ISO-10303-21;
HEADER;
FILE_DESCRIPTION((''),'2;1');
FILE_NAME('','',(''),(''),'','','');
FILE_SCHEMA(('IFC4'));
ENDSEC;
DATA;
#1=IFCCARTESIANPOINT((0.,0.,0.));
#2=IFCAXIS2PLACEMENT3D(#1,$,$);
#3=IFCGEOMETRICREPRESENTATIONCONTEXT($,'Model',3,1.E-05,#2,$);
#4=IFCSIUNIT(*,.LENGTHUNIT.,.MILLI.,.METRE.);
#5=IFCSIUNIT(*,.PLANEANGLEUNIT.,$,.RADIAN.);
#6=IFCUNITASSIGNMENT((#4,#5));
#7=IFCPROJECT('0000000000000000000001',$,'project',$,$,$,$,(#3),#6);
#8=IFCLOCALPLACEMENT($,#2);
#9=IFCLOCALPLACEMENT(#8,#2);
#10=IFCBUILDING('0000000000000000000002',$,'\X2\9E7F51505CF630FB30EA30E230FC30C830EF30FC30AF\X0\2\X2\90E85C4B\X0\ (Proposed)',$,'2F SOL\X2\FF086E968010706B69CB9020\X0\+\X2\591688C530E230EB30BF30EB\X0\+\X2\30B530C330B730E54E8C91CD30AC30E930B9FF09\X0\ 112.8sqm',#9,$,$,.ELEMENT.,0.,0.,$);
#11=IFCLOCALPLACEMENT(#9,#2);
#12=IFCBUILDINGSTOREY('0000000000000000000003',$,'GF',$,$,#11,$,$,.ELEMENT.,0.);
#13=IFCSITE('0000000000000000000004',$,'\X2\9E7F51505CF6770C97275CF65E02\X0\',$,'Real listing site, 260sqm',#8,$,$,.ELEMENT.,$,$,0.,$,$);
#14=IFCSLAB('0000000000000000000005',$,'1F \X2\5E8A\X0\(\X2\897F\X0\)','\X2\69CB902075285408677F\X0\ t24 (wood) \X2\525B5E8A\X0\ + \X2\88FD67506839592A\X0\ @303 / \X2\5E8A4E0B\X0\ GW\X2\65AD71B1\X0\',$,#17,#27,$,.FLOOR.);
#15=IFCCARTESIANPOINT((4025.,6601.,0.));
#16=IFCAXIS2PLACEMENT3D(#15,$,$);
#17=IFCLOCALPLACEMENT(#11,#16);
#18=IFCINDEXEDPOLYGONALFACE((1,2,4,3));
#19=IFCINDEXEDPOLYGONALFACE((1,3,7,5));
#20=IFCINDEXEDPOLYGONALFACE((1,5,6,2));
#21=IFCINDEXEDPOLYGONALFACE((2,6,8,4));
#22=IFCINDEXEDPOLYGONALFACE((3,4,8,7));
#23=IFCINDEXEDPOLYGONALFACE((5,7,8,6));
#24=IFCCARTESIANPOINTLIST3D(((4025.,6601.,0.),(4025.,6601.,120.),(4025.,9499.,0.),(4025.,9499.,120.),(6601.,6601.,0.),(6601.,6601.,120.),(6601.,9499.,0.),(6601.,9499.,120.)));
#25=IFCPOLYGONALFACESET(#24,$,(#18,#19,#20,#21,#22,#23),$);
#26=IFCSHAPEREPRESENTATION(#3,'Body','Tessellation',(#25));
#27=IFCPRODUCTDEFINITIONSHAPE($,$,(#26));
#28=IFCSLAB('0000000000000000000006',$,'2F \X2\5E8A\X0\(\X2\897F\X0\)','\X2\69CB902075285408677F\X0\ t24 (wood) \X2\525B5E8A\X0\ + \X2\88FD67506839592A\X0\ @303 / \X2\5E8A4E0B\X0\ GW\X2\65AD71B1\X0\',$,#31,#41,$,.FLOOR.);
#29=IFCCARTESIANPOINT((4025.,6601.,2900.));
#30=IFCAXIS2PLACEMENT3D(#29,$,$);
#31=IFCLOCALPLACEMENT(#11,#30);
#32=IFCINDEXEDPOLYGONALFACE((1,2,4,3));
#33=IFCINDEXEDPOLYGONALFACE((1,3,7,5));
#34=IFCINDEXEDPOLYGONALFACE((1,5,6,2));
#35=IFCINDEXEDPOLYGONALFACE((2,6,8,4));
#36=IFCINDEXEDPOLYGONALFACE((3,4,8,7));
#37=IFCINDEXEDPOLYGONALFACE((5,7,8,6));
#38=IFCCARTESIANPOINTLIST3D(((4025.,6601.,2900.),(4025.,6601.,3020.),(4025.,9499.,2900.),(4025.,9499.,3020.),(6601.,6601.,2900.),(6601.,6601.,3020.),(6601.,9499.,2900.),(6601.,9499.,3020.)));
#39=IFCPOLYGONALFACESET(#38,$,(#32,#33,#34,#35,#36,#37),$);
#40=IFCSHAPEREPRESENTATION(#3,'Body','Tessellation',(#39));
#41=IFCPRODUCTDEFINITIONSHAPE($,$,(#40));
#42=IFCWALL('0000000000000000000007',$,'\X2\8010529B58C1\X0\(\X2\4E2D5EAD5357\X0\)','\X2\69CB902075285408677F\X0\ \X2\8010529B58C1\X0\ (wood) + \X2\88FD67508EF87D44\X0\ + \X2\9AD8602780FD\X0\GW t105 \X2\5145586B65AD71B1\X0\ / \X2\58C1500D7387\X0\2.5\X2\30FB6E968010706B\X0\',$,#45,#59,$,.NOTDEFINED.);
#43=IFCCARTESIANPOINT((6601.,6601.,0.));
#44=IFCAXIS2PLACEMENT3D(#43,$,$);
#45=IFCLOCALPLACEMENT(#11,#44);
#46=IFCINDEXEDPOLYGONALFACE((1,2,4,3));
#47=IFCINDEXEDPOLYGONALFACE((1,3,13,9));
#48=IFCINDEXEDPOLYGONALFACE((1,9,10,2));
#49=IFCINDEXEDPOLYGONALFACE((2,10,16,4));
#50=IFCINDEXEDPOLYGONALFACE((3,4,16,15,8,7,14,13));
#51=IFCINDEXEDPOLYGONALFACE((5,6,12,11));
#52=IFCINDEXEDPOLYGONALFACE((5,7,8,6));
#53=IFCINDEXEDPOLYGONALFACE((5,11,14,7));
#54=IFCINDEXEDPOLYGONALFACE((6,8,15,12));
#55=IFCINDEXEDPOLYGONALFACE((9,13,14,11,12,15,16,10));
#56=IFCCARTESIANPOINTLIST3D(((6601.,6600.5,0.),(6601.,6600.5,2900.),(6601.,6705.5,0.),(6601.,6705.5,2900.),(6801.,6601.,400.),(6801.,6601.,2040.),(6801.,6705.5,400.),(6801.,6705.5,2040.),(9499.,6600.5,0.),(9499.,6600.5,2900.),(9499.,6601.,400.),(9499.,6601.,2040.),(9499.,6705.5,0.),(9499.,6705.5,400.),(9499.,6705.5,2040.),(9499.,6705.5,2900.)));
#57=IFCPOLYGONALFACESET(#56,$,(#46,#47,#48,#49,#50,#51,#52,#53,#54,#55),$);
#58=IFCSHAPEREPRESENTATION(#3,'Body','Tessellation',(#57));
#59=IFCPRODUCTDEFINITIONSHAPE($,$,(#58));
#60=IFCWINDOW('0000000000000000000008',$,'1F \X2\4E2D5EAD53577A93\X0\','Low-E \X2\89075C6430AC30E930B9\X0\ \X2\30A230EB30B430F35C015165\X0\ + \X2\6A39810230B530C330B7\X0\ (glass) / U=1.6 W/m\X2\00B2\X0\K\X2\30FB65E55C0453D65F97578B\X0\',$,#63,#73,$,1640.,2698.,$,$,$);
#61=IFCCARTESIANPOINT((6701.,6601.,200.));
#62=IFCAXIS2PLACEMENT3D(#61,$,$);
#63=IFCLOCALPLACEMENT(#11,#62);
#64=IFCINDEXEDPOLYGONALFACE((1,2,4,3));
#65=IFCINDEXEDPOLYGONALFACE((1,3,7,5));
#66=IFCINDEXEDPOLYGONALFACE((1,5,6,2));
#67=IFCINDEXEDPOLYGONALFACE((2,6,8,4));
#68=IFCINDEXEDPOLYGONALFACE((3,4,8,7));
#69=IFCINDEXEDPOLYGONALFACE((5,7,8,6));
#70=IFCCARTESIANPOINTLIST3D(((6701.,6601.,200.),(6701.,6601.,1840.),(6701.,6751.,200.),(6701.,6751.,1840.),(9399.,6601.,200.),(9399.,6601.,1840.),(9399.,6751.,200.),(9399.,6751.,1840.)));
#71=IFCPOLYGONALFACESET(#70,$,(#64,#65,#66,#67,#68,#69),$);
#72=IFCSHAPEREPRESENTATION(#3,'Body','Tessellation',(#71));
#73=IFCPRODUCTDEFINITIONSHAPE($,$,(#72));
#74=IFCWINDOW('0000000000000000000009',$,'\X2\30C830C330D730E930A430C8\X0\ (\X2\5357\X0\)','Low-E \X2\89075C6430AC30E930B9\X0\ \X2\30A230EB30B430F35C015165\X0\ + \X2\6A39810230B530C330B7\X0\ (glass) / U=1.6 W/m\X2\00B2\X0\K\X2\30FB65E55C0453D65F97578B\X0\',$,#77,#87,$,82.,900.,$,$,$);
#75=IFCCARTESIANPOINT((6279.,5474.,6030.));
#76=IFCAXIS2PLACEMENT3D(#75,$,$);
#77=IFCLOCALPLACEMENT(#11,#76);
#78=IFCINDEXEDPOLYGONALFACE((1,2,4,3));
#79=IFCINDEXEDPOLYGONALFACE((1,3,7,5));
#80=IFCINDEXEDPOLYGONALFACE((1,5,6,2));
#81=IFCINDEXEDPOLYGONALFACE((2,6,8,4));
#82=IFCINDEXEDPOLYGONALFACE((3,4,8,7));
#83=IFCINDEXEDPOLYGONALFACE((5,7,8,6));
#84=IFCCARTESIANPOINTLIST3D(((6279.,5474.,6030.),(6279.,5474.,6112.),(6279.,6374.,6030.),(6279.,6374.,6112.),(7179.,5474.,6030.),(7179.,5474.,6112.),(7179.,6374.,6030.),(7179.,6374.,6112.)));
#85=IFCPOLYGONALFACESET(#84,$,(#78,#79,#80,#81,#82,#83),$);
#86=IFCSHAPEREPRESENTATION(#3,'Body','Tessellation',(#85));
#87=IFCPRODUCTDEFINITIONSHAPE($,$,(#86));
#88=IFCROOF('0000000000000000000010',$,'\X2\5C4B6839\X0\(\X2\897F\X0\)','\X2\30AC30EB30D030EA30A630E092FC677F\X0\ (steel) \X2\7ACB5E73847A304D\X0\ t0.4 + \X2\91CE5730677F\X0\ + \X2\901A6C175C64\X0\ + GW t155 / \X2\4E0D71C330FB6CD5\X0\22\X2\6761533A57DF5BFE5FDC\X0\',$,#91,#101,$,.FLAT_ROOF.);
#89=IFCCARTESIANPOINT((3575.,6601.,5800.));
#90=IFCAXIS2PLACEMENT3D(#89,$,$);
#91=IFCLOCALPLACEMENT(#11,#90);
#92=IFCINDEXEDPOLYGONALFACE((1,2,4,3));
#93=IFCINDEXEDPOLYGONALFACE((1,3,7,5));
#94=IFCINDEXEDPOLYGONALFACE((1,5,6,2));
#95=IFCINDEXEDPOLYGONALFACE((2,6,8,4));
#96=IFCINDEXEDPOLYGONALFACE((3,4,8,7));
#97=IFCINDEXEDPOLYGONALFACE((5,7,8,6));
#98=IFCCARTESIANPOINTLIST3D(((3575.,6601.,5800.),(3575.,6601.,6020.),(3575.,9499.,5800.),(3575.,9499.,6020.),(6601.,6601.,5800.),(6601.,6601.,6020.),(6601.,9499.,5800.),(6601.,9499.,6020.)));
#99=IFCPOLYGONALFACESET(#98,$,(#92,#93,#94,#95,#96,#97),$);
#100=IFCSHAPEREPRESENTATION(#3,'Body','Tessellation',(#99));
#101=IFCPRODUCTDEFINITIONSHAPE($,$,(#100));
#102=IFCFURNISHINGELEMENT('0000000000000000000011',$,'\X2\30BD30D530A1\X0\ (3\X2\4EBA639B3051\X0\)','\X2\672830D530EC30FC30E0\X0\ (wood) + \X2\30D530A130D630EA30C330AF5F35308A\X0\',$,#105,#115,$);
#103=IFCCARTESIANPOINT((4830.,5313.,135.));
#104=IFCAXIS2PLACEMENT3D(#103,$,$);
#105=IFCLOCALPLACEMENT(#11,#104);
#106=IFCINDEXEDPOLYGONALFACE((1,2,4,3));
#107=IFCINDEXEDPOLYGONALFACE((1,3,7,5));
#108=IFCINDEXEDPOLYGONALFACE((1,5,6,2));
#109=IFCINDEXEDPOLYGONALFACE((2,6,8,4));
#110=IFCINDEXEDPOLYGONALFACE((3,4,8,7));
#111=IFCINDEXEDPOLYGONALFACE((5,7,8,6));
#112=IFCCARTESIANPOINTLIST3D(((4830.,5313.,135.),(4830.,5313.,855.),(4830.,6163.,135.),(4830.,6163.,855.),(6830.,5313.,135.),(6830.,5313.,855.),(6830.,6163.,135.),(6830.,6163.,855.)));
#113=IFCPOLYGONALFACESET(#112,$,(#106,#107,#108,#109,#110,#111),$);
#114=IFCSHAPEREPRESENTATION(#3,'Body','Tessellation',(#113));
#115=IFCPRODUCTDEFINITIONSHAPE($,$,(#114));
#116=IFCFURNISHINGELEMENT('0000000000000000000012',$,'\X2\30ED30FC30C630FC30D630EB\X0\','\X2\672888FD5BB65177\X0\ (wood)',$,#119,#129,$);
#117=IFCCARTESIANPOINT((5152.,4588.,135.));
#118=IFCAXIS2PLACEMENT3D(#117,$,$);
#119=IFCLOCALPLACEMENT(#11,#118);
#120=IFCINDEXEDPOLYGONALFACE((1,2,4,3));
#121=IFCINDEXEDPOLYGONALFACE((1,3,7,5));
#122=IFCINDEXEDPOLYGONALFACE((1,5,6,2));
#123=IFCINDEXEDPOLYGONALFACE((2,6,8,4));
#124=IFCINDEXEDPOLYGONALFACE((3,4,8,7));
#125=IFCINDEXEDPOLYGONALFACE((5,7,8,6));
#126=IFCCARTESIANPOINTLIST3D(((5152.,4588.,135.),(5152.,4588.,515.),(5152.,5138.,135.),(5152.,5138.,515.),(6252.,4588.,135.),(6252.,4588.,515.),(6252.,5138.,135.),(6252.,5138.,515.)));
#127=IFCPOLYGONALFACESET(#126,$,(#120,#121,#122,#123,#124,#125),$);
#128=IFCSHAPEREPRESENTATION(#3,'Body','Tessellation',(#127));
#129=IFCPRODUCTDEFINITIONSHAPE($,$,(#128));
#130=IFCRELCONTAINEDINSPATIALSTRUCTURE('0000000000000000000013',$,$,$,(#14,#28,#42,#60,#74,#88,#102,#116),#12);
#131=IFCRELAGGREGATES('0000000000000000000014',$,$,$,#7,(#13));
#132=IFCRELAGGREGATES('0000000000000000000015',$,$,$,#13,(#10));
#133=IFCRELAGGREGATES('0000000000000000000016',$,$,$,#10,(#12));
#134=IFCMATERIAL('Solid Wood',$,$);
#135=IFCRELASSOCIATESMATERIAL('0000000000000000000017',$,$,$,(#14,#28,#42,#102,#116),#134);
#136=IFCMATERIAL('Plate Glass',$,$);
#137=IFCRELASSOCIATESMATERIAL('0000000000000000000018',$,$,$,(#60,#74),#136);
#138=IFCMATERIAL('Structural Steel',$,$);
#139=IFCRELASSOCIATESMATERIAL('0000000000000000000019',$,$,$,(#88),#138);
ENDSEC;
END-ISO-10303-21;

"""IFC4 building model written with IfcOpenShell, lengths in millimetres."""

from ifc_helpers import new_model, si_unit, frame, frame_2d, origin, place, context, project, spatial, rectangle, extrude, material, element, fill, save


model = new_model("IFC4")

# Units and contexts
model_context = context("Model", 3, precision=1e-05, world=origin())
ifc_project = project(units=[si_unit("LENGTHUNIT", "METRE", prefix="MILLI"), si_unit("PLANEANGLEUNIT", "RADIAN")], contexts=[model_context])

# Site, building, storey
site_placement = place(None, origin())
site = spatial("IfcSite", under=ifc_project, at=site_placement, Name="鹿児島県霧島市", ObjectType="Real listing site, 260sqm", CompositionType="ELEMENT", RefElevation=0.0)
building_placement = place(site_placement, origin())
building = spatial("IfcBuilding", under=site, at=building_placement, Name="鹿児島・リモートワーク2部屋 (Proposed)", ObjectType="2F SOL（準耐火構造+外装モルタル+サッシュ二重ガラス） 112.8sqm", CompositionType="ELEMENT", ElevationOfRefHeight=0.0, ElevationOfTerrain=0.0)
storey_placement = place(building_placement, origin())
storey = spatial("IfcBuildingStorey", under=building, at=storey_placement, Name="GF", CompositionType="ELEMENT", Elevation=0.0)

# Shared definitions
ifc_material_1 = material(Name="Solid Wood")

# Slabs
slab_1_placement = place(storey_placement, frame((4025.0, 6601.0, 0.0)))
element("IfcSlab", 1, at=slab_1_placement, inside=storey, material=ifc_material_1, Name="1F 床(西)", Description="構造用合板 t24 (wood) 剛床 + 製材根太 @303 / 床下 GW断熱", PredefinedType="FLOOR", context=model_context, shape_type="SweptSolid", body=[
    extrude(rectangle(XDim=2576.0, YDim=2898.0, at=frame_2d((1288.0, 1449.0))), frame((4025.0, 6601.0, 0.0)), (0.0, 0.0, 1.0), 120.0),
])
slab_2_placement = place(storey_placement, frame((4025.0, 6601.0, 2900.0)))
element("IfcSlab", 2, at=slab_2_placement, inside=storey, material=ifc_material_1, Name="2F 床(西)", Description="構造用合板 t24 (wood) 剛床 + 製材根太 @303 / 床下 GW断熱", PredefinedType="FLOOR", context=model_context, shape_type="SweptSolid", body=[
    extrude(rectangle(XDim=2576.0, YDim=2898.0, at=frame_2d((1288.0, 1449.0))), frame((4025.0, 6601.0, 2900.0)), (0.0, 0.0, 1.0), 120.0),
])

# Wall, opening, window
wall_placement = place(storey_placement, frame((6601.0, 6601.0, 0.0)))
wall = element("IfcWall", 3, at=wall_placement, inside=storey, material=ifc_material_1, Name="耐力壁(中庭南)", Description="構造用合板 耐力壁 (wood) + 製材軸組 + 高性能GW t105 充填断熱 / 壁倍率2.5・準耐火", PredefinedType="NOTDEFINED", context=model_context, shape_type="SweptSolid", body=[
    extrude(rectangle(XDim=2898.0, YDim=105.0, at=frame_2d((1449.0, 52.0))), frame((6601.0, 6601.0, 0.0)), (0.0, 0.0, 1.0), 2900.0),
])
opening_placement = place(storey_placement, frame((6701.0, 6601.0, 200.0)))
opening = element("IfcOpeningElement", 4, at=opening_placement, cuts=wall, PredefinedType="NOTDEFINED", context=model_context, shape_type="SweptSolid", body=[
    extrude(rectangle(XDim=2698.0, YDim=150.0, at=frame_2d((1349.0, 75.0))), frame((6701.0, 6601.0, 200.0)), (0.0, 0.0, 1.0), 1640.0),
])
ifc_material_2 = material(Name="Plate Glass")
window_1_placement = place(storey_placement, frame((6701.0, 6601.0, 200.0)))
window_1 = element("IfcWindow", 5, at=window_1_placement, inside=storey, material=ifc_material_2, Name="1F 中庭南窓", Description="Low-E 複層ガラス アルゴン封入 + 樹脂サッシ (glass) / U=1.6 W/m²K・日射取得型", OverallHeight=1640.0, OverallWidth=2698.0, context=model_context, shape_type="SweptSolid", body=[
    extrude(rectangle(XDim=2698.0, YDim=150.0, at=frame_2d((1349.0, 75.0))), frame((6701.0, 6601.0, 200.0)), (0.0, 0.0, 1.0), 1640.0),
])
fill(opening, window_1)

# Window
window_2_placement = place(storey_placement, frame((6279.0, 5474.0, 6030.0)))
element("IfcWindow", 6, at=window_2_placement, inside=storey, material=ifc_material_2, Name="トップライト (南)", Description="Low-E 複層ガラス アルゴン封入 + 樹脂サッシ (glass) / U=1.6 W/m²K・日射取得型", OverallHeight=82.0, OverallWidth=900.0, context=model_context, shape_type="SweptSolid", body=[
    extrude(rectangle(XDim=900.0, YDim=900.0, at=frame_2d((450.0, 450.0))), frame((6279.0, 5474.0, 6030.0)), (0.0, 0.0, 1.0), 82.0),
])

# Roof
ifc_material_3 = material(Name="Structural Steel")
for number, where, name in (
    (7, (3575.0, 6601.0, 5800.0), "屋根(西)"),
):
    element("IfcRoof", number, at=place(storey_placement, frame(where)), inside=storey, material=ifc_material_3, Name=name, Description="ガルバリウム鋼板 (steel) 立平葺き t0.4 + 野地板 + 通気層 + GW t155 / 不燃・法22条区域対応", PredefinedType="FLAT_ROOF", context=model_context, shape_type="SweptSolid", body=[
        extrude(rectangle(XDim=3026.0, YDim=2898.0, at=frame_2d((1513.0, 1449.0))), frame((3575.0, 6601.0, 5800.0)), (0.0, 0.0, 1.0), 220.0),
    ])

# Furnishing elements
furnishing_1_placement = place(storey_placement, frame((4830.0, 5313.0, 135.0)))
element("IfcFurnishingElement", 8, at=furnishing_1_placement, inside=storey, material=ifc_material_1, Name="ソファ (3人掛け)", Description="木フレーム (wood) + ファブリック張り", context=model_context, shape_type="SweptSolid", body=[
    extrude(rectangle(XDim=2000.0, YDim=850.0, at=frame_2d((1000.0, 425.0))), frame((4830.0, 5313.0, 135.0)), (0.0, 0.0, 1.0), 720.0),
])
furnishing_2_placement = place(storey_placement, frame((5152.0, 4588.0, 135.0)))
element("IfcFurnishingElement", 9, at=furnishing_2_placement, inside=storey, material=ifc_material_1, Name="ローテーブル", Description="木製家具 (wood)", context=model_context, shape_type="SweptSolid", body=[
    extrude(rectangle(XDim=1100.0, YDim=550.0, at=frame_2d((550.0, 275.0))), frame((5152.0, 4588.0, 135.0)), (0.0, 0.0, 1.0), 380.0),
])

save(model, "model.ifc")
